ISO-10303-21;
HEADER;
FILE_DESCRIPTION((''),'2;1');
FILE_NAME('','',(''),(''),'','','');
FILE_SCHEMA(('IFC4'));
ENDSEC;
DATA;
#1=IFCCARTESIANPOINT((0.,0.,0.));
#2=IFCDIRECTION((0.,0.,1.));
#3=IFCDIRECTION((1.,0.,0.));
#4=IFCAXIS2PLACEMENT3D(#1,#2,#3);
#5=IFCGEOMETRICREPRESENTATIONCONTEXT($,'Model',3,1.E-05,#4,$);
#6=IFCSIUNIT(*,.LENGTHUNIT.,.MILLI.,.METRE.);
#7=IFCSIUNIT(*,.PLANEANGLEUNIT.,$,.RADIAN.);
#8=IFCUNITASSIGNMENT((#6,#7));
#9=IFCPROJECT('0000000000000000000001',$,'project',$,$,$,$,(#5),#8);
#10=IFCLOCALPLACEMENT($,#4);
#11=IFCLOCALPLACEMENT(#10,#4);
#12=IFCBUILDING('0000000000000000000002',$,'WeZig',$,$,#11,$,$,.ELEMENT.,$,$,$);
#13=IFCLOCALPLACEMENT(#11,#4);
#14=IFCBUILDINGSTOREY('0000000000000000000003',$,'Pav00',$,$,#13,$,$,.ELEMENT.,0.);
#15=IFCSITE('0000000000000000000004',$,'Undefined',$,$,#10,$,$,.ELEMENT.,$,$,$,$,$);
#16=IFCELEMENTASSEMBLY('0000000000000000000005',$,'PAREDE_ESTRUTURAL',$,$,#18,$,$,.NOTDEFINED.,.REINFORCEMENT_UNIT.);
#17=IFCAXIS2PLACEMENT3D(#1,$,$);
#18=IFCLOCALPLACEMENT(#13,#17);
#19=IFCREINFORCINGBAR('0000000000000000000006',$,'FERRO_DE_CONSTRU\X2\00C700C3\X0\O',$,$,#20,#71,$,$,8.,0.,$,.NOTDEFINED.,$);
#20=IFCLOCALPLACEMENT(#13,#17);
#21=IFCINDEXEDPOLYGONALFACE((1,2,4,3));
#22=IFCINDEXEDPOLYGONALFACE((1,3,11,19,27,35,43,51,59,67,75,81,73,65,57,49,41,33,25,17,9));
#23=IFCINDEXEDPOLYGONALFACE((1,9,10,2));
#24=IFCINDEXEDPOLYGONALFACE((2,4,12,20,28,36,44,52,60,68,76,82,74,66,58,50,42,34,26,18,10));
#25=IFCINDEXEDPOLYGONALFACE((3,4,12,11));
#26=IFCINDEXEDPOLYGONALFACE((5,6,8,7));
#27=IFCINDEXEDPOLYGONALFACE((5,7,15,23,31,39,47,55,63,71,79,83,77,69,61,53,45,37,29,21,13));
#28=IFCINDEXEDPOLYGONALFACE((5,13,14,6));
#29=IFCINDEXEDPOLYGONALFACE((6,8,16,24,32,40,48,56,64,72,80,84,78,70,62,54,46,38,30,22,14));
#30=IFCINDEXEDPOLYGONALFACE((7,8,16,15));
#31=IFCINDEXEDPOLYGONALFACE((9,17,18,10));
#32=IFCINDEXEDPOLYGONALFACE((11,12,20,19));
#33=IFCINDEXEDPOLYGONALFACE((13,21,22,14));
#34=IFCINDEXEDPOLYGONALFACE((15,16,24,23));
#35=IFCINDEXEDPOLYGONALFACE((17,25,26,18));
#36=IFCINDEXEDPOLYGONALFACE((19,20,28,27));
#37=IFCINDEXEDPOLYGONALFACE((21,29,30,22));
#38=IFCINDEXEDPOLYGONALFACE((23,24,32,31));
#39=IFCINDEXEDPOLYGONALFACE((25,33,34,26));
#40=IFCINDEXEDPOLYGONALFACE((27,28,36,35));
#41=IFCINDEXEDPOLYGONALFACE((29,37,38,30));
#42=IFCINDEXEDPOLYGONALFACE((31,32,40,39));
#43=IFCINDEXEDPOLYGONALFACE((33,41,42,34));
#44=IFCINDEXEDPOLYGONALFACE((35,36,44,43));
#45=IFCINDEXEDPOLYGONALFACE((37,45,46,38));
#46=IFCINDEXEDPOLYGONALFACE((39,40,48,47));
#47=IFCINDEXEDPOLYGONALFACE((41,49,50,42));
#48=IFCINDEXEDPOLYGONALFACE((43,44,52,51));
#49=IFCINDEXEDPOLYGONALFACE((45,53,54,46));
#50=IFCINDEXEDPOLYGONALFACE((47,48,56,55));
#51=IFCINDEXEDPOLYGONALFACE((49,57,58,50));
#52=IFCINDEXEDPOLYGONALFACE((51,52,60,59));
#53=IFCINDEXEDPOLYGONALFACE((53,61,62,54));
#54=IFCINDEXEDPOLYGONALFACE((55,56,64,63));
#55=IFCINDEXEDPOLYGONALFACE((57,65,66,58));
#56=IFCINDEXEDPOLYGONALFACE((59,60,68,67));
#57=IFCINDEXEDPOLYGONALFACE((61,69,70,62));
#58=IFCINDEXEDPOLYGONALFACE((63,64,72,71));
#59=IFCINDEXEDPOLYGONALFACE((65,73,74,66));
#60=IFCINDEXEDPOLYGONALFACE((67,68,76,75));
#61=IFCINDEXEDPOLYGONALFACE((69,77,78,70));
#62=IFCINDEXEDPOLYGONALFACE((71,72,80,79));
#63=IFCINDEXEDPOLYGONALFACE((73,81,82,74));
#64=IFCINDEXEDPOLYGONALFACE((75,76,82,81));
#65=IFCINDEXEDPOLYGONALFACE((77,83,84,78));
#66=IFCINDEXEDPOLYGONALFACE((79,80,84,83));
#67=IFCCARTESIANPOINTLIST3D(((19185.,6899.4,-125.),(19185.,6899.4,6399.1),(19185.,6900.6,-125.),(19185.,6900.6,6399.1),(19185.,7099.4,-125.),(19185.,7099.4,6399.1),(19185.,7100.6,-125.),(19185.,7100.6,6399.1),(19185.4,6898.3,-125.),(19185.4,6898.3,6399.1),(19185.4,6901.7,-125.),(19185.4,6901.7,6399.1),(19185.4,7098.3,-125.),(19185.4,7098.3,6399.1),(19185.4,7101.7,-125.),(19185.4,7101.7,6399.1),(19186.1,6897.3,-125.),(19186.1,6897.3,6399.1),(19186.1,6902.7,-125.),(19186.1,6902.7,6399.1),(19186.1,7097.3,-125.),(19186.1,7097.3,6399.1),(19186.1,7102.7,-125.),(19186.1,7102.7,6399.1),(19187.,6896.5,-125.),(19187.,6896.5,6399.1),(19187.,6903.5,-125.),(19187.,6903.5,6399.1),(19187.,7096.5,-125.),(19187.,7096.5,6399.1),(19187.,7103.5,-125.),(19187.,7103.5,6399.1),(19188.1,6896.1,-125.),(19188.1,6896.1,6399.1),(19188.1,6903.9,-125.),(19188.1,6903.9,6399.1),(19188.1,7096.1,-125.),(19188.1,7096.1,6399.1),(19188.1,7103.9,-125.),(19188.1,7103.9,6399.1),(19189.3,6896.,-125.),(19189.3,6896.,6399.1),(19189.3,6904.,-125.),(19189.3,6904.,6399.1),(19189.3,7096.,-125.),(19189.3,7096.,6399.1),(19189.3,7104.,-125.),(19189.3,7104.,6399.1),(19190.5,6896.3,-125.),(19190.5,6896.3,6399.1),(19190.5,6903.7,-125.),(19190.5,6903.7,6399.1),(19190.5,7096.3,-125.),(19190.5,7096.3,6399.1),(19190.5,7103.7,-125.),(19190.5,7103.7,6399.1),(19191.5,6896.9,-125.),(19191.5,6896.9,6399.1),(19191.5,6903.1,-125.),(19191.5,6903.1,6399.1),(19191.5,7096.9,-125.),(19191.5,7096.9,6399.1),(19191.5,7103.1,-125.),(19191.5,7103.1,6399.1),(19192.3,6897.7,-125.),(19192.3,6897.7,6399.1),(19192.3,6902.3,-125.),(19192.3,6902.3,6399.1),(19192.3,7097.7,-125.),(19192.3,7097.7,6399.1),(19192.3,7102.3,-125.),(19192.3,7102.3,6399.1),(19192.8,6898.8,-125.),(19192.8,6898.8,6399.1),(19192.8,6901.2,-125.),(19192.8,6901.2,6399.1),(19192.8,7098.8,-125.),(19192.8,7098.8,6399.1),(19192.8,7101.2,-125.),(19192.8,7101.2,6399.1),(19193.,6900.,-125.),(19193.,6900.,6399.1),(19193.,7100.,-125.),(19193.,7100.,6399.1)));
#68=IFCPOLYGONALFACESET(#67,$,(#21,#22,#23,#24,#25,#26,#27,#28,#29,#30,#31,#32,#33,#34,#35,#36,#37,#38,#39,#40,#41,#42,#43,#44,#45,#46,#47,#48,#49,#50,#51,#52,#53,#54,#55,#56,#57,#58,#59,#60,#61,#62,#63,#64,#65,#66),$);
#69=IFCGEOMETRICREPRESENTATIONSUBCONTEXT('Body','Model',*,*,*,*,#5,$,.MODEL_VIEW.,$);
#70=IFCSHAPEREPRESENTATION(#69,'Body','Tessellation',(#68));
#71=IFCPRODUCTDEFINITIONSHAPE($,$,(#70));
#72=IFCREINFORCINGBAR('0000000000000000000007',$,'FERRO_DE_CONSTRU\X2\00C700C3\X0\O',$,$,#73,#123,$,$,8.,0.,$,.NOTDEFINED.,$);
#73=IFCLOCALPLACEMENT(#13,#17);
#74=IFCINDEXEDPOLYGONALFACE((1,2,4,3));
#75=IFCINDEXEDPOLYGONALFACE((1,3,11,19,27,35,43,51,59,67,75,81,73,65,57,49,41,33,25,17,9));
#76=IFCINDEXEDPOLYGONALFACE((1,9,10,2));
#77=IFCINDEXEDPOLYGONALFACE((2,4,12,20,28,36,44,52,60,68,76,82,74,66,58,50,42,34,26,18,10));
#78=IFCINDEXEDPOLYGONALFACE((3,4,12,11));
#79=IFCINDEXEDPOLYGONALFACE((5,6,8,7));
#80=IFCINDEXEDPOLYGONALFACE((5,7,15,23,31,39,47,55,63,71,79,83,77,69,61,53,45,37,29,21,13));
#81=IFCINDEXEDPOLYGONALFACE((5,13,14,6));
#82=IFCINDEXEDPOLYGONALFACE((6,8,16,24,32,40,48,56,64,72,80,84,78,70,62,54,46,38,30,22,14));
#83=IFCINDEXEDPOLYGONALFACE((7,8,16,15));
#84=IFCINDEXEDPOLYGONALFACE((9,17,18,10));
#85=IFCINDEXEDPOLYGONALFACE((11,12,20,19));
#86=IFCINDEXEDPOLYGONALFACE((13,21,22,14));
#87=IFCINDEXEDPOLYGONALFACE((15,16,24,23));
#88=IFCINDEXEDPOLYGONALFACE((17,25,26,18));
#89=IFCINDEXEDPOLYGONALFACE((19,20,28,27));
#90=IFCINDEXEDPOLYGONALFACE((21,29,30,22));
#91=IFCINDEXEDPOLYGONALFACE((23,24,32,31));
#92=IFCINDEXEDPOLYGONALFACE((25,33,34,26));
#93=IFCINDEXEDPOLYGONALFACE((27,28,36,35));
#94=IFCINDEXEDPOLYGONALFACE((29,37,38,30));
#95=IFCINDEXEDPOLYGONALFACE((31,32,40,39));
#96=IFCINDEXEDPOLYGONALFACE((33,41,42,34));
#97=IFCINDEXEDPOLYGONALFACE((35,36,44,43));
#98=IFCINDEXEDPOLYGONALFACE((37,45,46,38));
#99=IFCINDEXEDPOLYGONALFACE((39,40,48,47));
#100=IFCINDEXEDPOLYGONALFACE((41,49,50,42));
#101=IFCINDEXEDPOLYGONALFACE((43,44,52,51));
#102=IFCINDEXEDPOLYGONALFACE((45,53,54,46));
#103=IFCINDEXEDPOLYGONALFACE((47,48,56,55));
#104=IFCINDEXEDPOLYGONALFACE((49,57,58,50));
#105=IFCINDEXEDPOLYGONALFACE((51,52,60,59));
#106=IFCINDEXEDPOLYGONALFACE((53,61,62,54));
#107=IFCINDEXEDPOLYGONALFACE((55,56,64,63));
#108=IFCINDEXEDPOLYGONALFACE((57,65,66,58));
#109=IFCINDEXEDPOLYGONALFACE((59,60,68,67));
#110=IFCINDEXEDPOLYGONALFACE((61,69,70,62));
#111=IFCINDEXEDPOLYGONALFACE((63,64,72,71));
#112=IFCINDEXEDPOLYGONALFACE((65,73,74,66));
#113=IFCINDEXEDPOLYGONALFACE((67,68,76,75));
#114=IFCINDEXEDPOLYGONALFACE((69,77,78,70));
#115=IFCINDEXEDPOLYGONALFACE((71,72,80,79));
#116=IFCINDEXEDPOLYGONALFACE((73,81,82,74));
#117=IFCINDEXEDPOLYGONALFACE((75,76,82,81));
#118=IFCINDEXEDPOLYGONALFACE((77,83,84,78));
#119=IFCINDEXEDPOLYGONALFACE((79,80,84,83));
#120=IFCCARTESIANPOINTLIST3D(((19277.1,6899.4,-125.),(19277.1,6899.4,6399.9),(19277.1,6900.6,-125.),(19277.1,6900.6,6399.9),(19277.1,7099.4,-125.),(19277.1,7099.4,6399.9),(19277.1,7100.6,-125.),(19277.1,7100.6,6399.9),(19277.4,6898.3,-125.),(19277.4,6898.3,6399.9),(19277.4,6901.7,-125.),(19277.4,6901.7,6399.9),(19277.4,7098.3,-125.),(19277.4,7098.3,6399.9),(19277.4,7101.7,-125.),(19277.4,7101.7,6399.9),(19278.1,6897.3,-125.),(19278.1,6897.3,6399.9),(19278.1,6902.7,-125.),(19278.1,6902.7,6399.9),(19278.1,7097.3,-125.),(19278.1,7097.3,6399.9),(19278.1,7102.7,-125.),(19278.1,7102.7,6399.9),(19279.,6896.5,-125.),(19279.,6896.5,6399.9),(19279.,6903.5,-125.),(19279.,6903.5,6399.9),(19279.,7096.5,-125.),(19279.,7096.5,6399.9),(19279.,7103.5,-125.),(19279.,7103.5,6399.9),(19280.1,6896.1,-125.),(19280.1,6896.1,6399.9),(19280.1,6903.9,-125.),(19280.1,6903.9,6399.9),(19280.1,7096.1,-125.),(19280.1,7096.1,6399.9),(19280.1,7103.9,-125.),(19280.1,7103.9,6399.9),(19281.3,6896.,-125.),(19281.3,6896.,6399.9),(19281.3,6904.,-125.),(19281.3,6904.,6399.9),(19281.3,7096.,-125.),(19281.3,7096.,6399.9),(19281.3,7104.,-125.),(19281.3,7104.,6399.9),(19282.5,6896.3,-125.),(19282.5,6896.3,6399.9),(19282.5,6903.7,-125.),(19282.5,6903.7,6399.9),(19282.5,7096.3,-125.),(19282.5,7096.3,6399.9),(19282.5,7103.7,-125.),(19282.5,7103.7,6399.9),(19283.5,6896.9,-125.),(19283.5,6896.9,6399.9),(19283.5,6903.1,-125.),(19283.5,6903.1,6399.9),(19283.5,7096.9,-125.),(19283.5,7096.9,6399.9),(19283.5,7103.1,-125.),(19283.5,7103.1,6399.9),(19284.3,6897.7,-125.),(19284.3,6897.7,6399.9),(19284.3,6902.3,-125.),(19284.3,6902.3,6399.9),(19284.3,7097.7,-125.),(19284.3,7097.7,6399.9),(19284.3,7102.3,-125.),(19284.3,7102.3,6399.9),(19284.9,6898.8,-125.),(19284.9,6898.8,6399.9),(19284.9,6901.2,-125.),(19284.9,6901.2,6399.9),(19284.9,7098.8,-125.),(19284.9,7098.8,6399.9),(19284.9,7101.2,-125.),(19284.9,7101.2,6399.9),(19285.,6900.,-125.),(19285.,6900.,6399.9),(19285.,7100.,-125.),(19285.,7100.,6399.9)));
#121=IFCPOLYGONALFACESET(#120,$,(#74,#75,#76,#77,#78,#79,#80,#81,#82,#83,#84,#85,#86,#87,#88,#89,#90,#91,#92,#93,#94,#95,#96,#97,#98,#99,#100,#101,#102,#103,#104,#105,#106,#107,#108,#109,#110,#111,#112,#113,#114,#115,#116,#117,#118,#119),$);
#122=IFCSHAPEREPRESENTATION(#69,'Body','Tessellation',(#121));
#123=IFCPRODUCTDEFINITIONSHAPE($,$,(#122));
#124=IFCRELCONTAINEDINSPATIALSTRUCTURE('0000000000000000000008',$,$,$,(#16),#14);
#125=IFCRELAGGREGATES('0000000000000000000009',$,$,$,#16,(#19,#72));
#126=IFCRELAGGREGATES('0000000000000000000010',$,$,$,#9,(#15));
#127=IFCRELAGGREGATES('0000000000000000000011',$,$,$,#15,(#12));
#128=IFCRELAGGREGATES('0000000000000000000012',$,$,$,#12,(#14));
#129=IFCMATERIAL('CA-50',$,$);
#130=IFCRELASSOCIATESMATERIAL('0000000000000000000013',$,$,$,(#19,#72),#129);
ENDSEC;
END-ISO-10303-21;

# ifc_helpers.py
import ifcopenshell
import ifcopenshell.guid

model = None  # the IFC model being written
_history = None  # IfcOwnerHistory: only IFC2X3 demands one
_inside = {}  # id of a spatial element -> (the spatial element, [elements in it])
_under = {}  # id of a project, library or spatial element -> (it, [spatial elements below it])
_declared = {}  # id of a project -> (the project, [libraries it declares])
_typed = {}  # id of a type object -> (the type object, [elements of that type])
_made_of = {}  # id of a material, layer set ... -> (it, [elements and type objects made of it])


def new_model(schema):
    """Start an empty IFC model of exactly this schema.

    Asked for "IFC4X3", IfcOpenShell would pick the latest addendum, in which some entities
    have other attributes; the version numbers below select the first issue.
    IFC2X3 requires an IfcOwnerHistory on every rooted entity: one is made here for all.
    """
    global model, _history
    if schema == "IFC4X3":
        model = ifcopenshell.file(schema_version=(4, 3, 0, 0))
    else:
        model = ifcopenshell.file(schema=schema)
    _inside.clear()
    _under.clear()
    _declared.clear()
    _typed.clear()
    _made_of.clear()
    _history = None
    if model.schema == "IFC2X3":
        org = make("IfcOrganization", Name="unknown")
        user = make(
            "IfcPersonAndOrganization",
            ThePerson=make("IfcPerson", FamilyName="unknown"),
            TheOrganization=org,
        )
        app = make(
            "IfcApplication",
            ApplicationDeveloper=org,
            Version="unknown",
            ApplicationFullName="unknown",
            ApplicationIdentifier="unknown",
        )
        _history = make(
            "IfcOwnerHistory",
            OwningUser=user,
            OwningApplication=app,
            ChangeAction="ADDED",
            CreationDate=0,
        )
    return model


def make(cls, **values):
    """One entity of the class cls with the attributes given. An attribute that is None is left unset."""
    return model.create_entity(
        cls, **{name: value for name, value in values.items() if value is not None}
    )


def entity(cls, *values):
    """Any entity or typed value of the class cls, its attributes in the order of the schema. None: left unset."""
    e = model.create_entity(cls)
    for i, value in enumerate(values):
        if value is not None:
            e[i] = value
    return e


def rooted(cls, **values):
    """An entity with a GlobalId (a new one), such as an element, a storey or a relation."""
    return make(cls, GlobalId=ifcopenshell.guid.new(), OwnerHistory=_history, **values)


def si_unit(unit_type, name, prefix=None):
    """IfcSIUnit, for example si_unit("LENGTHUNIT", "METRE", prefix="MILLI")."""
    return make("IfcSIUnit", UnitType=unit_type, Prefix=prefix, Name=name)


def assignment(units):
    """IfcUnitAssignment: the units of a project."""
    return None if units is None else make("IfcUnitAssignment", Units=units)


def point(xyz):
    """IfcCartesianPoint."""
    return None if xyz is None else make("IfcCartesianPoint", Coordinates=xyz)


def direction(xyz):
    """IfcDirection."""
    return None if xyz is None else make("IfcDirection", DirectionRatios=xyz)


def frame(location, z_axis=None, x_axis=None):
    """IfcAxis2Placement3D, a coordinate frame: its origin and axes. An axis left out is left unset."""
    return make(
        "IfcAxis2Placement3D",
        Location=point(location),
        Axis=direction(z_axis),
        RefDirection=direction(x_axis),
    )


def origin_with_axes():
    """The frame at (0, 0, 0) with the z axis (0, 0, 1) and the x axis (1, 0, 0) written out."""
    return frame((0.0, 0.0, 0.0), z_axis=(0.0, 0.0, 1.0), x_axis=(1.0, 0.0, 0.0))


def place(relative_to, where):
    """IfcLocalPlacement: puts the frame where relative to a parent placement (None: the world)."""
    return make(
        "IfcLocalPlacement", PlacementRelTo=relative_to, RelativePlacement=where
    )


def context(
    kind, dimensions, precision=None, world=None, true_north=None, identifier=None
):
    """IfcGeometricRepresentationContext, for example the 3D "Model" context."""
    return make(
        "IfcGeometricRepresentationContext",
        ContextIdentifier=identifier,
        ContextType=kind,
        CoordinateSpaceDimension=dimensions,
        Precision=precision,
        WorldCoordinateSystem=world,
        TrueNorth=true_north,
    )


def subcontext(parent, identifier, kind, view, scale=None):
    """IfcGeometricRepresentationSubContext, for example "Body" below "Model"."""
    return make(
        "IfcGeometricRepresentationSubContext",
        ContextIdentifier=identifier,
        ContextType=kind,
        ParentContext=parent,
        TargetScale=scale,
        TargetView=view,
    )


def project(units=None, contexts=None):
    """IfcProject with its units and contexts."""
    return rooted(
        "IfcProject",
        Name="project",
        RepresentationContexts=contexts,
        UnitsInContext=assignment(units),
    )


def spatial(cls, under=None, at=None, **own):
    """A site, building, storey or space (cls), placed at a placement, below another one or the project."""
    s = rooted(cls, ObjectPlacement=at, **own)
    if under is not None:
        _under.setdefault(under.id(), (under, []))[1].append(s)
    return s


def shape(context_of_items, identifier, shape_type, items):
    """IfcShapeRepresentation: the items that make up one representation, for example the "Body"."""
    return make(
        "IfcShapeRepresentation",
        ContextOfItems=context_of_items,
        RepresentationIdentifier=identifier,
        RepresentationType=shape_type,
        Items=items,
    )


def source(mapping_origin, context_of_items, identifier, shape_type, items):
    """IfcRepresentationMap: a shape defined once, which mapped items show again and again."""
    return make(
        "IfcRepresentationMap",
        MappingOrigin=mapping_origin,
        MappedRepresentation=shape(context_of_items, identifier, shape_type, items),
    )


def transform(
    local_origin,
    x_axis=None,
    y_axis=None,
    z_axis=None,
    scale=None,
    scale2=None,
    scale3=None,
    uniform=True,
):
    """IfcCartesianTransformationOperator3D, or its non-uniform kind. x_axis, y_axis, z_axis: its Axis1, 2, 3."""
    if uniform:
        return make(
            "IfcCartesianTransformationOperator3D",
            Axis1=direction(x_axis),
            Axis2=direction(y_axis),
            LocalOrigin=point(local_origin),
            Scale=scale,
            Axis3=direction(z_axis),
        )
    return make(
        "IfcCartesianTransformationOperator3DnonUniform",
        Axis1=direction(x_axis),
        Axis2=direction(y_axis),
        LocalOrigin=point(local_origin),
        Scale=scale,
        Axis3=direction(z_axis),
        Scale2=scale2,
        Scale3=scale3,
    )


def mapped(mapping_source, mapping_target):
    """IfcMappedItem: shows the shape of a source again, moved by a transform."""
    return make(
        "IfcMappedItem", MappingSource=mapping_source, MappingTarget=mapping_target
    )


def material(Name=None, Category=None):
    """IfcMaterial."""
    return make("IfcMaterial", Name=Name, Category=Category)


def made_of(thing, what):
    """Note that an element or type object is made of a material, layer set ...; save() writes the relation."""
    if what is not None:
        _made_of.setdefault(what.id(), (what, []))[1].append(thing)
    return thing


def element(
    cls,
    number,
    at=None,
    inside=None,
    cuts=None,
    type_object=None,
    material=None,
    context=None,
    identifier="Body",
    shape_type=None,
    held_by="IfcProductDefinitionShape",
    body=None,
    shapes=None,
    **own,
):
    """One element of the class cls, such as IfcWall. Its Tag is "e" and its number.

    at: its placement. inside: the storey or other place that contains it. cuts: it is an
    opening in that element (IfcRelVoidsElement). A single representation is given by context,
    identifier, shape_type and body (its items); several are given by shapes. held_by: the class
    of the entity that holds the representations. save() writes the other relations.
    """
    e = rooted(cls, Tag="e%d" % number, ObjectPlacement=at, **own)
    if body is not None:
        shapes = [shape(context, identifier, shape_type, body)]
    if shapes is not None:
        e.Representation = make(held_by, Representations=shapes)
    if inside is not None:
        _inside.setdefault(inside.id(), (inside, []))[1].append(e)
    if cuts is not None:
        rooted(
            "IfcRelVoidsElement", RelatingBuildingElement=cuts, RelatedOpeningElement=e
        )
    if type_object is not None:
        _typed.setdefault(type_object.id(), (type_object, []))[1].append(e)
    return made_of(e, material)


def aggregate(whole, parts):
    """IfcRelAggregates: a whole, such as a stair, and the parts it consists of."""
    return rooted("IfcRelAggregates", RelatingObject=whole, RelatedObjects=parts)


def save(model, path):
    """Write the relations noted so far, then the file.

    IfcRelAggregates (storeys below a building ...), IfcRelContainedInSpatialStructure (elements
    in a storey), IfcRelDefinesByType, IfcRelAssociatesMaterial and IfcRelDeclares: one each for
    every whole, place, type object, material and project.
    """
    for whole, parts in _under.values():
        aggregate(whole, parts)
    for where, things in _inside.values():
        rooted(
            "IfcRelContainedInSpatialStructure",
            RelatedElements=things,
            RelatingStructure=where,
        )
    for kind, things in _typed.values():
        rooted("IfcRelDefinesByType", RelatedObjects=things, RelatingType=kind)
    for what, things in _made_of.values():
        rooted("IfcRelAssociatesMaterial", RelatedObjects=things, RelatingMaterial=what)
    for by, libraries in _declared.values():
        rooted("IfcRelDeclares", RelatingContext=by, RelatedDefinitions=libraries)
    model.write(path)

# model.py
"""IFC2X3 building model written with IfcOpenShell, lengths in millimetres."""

from ifc_helpers import new_model, entity, si_unit, frame, origin_with_axes, place, context, subcontext, project, spatial, source, transform, mapped, material, element, aggregate, save


model = new_model("IFC2X3")

# Units and contexts
model_context = context("Model", 3, precision=1e-05, world=origin_with_axes())
body_context = subcontext(model_context, "Body", "Model", "MODEL_VIEW")
ifc_project = project(units=[si_unit("LENGTHUNIT", "METRE", prefix="MILLI"), si_unit("PLANEANGLEUNIT", "RADIAN")], contexts=[model_context])

# Site, building, storey
site_placement = place(None, origin_with_axes())
site = spatial("IfcSite", under=ifc_project, at=site_placement, Name="Undefined", CompositionType="ELEMENT")
building_placement = place(site_placement, origin_with_axes())
building = spatial("IfcBuilding", under=site, at=building_placement, Name="WeZig", CompositionType="ELEMENT")
storey_placement = place(building_placement, origin_with_axes())
storey = spatial("IfcBuildingStorey", under=building, at=storey_placement, Name="Pav00", CompositionType="ELEMENT", Elevation=0.0)

# Shared definitions
ifc_material_1 = material(Name="CA-50")

# Element assembly, reinforcing bars
assembly_1_placement = place(storey_placement, origin_with_axes())
assembly_1 = element("IfcElementAssembly", 1, at=assembly_1_placement, inside=storey, Name="PAREDE_ESTRUTURAL", AssemblyPlace="NOTDEFINED", PredefinedType="REINFORCEMENT_UNIT")
shared_shape_1 = source(origin_with_axes(), body_context, "Body", "AdvancedSweptSolid", [
    entity("IfcSweptDiskSolid", entity("IfcTrimmedCurve", entity("IfcLine", entity("IfcCartesianPoint", [0.0, 0.0, 0.0]), entity("IfcVector", entity("IfcDirection", [1.0, 0.0, 0.0]), 1.0)), [entity("IfcParameterValue", 0.0)], [entity("IfcParameterValue", 6524.064251)], True, "PARAMETER"), 4.0, None, 0.0, 6524.1),
])
shared_shape_2 = source(origin_with_axes(), body_context, "Body", "AdvancedSweptSolid", [
    entity("IfcSweptDiskSolid", entity("IfcTrimmedCurve", entity("IfcLine", entity("IfcCartesianPoint", [0.0, 0.0, 0.0]), entity("IfcVector", entity("IfcDirection", [1.0, 0.0, 0.0]), 1.0)), [entity("IfcParameterValue", 0.0)], [entity("IfcParameterValue", 6524.064251)], True, "PARAMETER"), 4.0, None, 0.0, 6524.1),
])
reinforcing_bar_1_placement = place(assembly_1_placement, frame((19189.0, 6900.0, 6399.1), z_axis=(1.0, 0.0, 0.0), x_axis=(0.0, 0.0, -1.0)))
reinforcing_bar_1 = element("IfcReinforcingBar", 2, at=reinforcing_bar_1_placement, material=ifc_material_1, Name="FERRO_DE_CONSTRUÇÃO", BarRole="NOTDEFINED", CrossSectionArea=0.0, NominalDiameter=8.0, context=body_context, shape_type="MappedRepresentation", body=[
    mapped(shared_shape_1, transform((0.0, 0.0, 0.0))),
    mapped(shared_shape_2, transform((0.0, 200.0, 0.0))),
])
shared_shape_3 = source(origin_with_axes(), body_context, "Body", "AdvancedSweptSolid", [
    entity("IfcSweptDiskSolid", entity("IfcTrimmedCurve", entity("IfcLine", entity("IfcCartesianPoint", [0.0, 0.0, 0.0]), entity("IfcVector", entity("IfcDirection", [1.0, 0.0, 0.0]), 1.0)), [entity("IfcParameterValue", 0.0)], [entity("IfcParameterValue", 6524.935933)], True, "PARAMETER"), 4.0, None, 0.0, 6524.9),
])
shared_shape_4 = source(origin_with_axes(), body_context, "Body", "AdvancedSweptSolid", [
    entity("IfcSweptDiskSolid", entity("IfcTrimmedCurve", entity("IfcLine", entity("IfcCartesianPoint", [0.0, 0.0, 0.0]), entity("IfcVector", entity("IfcDirection", [1.0, 0.0, 0.0]), 1.0)), [entity("IfcParameterValue", 0.0)], [entity("IfcParameterValue", 6524.935933)], True, "PARAMETER"), 4.0, None, 0.0, 6524.9),
])
reinforcing_bar_2_placement = place(assembly_1_placement, frame((19281.0, 6900.0, 6399.9), z_axis=(1.0, 0.0, 0.0), x_axis=(0.0, 0.0, -1.0)))
reinforcing_bar_2 = element("IfcReinforcingBar", 3, at=reinforcing_bar_2_placement, material=ifc_material_1, Name="FERRO_DE_CONSTRUÇÃO", BarRole="NOTDEFINED", CrossSectionArea=0.0, NominalDiameter=8.0, context=body_context, shape_type="MappedRepresentation", body=[
    mapped(shared_shape_3, transform((0.0, 0.0, 0.0))),
    mapped(shared_shape_4, transform((0.0, 200.0, 0.0))),
])
aggregate(assembly_1, [reinforcing_bar_1, reinforcing_bar_2])

save(model, "model.ifc")
